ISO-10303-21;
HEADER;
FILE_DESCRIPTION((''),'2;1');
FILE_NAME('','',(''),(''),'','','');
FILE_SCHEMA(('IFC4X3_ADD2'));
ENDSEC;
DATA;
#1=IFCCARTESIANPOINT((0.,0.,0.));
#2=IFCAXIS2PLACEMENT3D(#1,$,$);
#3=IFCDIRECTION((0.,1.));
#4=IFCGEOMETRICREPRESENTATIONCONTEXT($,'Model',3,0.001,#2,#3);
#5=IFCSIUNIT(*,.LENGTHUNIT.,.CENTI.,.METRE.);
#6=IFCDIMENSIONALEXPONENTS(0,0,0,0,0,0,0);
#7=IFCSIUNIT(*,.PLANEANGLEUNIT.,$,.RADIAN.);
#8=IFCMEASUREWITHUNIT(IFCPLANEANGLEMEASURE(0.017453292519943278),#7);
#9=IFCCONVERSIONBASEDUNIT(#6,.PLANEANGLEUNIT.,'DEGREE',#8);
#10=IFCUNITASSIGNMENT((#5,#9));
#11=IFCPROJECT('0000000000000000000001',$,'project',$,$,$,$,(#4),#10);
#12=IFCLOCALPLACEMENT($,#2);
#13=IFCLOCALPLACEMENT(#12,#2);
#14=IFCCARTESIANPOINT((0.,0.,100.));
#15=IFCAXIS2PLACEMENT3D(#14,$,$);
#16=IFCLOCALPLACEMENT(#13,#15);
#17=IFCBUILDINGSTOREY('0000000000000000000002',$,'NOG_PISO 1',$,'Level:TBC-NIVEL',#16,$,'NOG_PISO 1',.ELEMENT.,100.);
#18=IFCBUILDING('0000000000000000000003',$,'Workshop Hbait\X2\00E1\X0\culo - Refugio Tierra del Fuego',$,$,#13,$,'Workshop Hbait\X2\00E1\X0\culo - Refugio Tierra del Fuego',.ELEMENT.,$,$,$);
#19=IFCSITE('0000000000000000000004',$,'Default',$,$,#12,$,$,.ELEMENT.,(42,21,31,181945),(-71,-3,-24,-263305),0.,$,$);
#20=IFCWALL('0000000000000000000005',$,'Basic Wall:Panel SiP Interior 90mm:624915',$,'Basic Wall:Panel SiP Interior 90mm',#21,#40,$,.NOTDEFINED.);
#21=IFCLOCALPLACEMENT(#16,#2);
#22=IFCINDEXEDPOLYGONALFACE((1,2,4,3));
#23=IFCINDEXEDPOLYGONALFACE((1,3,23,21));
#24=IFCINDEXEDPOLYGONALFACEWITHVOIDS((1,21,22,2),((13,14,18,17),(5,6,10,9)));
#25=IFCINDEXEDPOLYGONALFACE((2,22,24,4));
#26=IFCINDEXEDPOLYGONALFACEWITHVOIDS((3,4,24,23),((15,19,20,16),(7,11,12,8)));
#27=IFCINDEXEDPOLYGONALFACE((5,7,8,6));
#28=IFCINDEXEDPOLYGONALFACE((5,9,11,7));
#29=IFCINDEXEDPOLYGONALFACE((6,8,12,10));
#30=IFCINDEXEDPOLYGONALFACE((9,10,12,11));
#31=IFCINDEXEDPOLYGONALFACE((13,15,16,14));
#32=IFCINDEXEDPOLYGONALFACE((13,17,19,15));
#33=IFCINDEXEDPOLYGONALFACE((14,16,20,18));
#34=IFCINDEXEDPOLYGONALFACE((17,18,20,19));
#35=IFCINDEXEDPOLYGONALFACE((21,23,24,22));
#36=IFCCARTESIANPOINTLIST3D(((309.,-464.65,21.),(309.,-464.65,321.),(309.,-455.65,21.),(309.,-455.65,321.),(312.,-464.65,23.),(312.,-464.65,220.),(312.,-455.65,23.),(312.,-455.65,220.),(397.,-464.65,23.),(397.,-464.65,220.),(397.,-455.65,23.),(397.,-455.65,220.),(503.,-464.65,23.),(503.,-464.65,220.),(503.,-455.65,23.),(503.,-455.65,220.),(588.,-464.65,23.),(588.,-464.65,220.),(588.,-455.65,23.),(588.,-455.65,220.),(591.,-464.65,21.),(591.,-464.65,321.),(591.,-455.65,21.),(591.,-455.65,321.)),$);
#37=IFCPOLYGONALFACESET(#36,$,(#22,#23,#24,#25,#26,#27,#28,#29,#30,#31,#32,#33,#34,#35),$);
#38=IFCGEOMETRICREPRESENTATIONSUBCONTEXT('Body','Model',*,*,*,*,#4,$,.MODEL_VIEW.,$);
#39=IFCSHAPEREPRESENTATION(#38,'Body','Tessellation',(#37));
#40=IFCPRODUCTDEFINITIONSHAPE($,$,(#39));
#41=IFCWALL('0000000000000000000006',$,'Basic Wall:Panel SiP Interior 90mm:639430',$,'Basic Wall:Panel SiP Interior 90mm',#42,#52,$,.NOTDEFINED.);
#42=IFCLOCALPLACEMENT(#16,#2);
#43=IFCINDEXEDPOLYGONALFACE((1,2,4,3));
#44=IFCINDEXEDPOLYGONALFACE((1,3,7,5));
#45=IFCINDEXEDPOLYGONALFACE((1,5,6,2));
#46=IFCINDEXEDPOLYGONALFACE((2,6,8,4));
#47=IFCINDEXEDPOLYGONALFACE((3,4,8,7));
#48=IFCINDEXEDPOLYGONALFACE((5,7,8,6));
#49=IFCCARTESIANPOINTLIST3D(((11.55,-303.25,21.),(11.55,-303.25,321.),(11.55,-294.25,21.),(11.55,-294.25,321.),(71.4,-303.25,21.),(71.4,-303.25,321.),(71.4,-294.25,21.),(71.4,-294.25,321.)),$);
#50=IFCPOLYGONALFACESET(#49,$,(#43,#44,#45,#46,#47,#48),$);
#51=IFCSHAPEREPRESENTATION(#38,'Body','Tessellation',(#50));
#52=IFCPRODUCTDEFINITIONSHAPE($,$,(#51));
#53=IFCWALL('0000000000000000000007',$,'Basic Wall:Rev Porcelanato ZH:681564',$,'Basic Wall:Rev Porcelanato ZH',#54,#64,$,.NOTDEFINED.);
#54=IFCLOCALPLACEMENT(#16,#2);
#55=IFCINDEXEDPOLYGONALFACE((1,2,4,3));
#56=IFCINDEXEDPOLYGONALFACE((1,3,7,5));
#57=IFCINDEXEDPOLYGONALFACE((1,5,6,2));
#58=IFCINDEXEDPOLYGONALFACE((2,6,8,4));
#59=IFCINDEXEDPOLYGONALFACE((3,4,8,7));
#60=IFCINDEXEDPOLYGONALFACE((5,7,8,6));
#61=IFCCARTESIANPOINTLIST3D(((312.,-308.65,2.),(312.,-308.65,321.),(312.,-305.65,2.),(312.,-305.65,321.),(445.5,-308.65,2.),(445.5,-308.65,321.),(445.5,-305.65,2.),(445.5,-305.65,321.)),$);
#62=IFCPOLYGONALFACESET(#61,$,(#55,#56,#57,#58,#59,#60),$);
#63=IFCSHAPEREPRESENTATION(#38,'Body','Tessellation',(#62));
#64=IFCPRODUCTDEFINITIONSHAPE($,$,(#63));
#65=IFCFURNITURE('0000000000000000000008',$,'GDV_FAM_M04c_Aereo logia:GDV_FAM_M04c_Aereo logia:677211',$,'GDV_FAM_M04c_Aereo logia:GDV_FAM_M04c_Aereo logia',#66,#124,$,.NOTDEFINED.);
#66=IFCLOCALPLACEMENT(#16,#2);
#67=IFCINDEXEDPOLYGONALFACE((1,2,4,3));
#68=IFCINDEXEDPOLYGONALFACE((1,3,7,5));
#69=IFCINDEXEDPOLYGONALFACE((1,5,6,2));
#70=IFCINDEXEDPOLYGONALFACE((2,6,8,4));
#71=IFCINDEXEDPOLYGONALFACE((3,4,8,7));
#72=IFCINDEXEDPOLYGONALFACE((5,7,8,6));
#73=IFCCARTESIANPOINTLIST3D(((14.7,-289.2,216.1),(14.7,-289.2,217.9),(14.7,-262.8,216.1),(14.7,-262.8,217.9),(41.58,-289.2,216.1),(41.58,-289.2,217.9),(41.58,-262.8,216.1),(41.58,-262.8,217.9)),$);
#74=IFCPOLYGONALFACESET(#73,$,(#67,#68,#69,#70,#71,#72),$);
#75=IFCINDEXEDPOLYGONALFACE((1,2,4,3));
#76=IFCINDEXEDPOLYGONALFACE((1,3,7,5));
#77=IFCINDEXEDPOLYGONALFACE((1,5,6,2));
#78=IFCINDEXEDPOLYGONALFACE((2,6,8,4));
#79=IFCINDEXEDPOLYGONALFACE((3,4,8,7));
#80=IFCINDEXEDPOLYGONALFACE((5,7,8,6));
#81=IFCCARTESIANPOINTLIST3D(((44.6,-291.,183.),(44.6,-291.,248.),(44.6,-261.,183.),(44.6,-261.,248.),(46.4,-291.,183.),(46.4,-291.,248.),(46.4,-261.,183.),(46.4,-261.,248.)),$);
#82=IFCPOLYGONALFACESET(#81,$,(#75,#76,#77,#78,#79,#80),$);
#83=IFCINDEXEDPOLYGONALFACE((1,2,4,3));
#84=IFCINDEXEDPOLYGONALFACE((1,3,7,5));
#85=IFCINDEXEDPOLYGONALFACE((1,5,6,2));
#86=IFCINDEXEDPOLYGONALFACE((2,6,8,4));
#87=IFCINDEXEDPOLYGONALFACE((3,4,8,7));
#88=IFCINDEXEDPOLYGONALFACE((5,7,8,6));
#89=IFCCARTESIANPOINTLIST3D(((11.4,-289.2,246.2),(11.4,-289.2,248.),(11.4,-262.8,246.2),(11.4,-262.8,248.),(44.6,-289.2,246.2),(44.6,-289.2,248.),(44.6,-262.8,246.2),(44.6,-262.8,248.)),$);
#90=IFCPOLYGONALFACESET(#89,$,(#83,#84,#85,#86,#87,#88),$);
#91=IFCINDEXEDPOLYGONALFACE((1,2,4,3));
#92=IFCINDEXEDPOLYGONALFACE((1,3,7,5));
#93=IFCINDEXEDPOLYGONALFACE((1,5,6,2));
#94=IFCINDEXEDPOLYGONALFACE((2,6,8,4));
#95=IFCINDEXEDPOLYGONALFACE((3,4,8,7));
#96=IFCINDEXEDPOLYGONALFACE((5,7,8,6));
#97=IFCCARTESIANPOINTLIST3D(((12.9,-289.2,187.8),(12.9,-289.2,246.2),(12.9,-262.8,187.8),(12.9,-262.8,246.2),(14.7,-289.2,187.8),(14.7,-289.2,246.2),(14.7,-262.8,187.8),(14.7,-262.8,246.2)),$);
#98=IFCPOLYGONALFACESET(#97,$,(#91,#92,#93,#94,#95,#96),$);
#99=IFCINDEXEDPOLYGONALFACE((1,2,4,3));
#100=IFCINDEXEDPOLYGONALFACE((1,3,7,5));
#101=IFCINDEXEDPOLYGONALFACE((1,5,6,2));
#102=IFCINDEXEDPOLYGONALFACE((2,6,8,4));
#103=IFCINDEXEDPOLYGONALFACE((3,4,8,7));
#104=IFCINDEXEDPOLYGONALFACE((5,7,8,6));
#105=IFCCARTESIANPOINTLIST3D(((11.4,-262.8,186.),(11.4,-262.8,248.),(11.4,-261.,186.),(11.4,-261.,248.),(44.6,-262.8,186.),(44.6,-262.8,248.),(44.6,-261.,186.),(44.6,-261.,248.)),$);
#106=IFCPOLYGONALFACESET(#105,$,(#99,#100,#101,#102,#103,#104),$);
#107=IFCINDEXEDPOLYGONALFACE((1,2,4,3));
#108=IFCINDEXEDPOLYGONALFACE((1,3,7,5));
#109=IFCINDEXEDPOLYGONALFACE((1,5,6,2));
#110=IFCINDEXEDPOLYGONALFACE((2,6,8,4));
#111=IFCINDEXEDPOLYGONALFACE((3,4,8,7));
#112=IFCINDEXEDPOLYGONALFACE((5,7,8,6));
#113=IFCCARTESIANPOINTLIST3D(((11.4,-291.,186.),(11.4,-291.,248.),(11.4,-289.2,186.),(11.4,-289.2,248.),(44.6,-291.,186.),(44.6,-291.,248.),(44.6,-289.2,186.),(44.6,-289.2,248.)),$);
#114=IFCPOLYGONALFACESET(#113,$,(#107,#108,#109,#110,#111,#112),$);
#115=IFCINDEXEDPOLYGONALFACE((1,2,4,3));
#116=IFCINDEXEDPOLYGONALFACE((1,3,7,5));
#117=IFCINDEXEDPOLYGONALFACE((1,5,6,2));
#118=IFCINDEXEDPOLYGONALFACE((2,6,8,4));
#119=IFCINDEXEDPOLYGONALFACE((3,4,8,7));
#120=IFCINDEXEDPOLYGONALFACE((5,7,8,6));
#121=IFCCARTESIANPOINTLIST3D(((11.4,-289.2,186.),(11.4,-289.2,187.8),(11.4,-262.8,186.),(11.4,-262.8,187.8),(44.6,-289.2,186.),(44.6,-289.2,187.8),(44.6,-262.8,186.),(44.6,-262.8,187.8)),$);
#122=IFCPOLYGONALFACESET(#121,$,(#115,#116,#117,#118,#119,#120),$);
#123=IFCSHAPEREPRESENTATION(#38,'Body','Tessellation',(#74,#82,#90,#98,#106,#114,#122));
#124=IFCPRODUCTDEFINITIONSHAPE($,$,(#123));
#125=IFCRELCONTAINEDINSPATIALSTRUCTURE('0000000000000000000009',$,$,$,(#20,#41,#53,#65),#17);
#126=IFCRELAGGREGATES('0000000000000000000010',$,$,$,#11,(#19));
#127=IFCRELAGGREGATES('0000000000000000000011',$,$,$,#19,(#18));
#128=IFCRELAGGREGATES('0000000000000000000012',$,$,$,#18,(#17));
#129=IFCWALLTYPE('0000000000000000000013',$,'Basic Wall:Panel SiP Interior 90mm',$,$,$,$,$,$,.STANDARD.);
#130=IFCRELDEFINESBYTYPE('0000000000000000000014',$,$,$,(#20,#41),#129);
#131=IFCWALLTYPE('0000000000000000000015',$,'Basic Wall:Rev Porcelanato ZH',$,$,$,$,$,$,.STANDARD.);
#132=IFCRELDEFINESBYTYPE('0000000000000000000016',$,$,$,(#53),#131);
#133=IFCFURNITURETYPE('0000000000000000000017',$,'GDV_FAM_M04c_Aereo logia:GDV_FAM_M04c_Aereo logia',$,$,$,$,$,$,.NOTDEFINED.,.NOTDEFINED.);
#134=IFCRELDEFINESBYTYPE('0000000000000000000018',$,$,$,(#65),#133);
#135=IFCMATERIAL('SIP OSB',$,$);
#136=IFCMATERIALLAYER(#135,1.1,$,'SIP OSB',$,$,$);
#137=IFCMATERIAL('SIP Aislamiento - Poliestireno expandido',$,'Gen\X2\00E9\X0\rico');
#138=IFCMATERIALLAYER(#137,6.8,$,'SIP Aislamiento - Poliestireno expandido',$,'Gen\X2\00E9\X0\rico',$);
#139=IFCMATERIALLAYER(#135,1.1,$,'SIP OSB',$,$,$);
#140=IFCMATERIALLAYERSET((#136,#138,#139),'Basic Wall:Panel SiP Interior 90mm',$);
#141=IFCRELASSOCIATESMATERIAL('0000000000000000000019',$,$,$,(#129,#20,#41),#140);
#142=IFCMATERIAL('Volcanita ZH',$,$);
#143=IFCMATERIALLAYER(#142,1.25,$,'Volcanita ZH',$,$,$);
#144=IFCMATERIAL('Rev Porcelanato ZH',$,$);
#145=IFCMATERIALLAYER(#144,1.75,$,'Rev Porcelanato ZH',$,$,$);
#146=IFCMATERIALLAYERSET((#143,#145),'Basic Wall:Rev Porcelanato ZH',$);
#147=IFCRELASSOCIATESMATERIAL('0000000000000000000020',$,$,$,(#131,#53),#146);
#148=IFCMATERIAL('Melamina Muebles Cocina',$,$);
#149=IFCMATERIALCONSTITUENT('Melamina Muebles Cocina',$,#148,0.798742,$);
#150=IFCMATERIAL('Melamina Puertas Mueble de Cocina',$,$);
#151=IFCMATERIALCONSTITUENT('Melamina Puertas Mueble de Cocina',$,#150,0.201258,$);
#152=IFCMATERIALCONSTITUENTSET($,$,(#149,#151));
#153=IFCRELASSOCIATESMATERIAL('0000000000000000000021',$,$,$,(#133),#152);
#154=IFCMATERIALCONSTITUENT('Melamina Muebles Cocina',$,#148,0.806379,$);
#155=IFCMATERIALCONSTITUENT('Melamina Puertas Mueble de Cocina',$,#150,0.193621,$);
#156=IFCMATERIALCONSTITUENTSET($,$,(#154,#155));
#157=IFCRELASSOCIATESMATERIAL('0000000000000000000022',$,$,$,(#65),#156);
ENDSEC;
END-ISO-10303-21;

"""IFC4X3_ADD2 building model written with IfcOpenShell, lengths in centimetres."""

from ifc_helpers import new_model, entity, si_unit, converted_unit, direction, frame, frame_2d, origin, origin_2d_with_axis, place, context, subcontext, project, spatial, rectangle, extrude, source, transform, mapped, material, layer, layer_set, constituent, constituent_set, type_object, type_shapes, element, save


model = new_model("IFC4X3_ADD2")

# Units and contexts
model_context = context("Model", 3, precision=0.001, world=origin(), true_north=direction((0.0, 1.0)))
body_context = subcontext(model_context, "Body", "Model", "MODEL_VIEW")
ifc_project = project(units=[si_unit("LENGTHUNIT", "METRE", prefix="CENTI"), converted_unit("PLANEANGLEUNIT", "DEGREE", entity("IfcPlaneAngleMeasure", 0.017453292519943278), si_unit("PLANEANGLEUNIT", "RADIAN"), dimensions=[0, 0, 0, 0, 0, 0, 0])], contexts=[model_context])

# Site, building, storey
site_placement = place(None, origin())
site = spatial("IfcSite", under=ifc_project, at=site_placement, Name="Default", CompositionType="ELEMENT", RefLatitude=(42, 21, 31, 181945), RefLongitude=(-71, -3, -24, -263305), RefElevation=0.0)
building_placement = place(site_placement, origin())
building = spatial("IfcBuilding", under=site, at=building_placement, Name="Workshop Hbaitáculo - Refugio Tierra del Fuego", LongName="Workshop Hbaitáculo - Refugio Tierra del Fuego", CompositionType="ELEMENT")
storey_placement = place(building_placement, frame((0.0, 0.0, 100.0)))
storey = spatial("IfcBuildingStorey", under=building, at=storey_placement, Name="NOG_PISO 1", ObjectType="Level:TBC-NIVEL", LongName="NOG_PISO 1", CompositionType="ELEMENT", Elevation=100.0)

# Shared definitions
ifc_material_1 = material(Name="SIP OSB")
ifc_material_2 = material(Name="SIP Aislamiento - Poliestireno expandido", Category="Genérico")

# Shared definitions
ifc_layer_1 = layer(ifc_material_1, 1.1, Name="SIP OSB")
ifc_layer_2 = layer(ifc_material_2, 6.8, Name="SIP Aislamiento - Poliestireno expandido", Category="Genérico")
ifc_layer_3 = layer(ifc_material_1, 1.1, Name="SIP OSB")
ifc_layer_set_1 = layer_set([ifc_layer_1, ifc_layer_2, ifc_layer_3], Name="Basic Wall:Panel SiP Interior 90mm")
wall_type_1 = type_object("IfcWallType", Name="Basic Wall:Panel SiP Interior 90mm", PredefinedType="STANDARD", material=ifc_layer_set_1)

# Wall, openings
wall_1_placement = place(storey_placement, frame((309.0, -460.15, 21.0)))
wall_1 = element("IfcWall", 1, at=wall_1_placement, inside=storey, type_object=wall_type_1, material=ifc_layer_set_1, Name="Basic Wall:Panel SiP Interior 90mm:624915", ObjectType="Basic Wall:Panel SiP Interior 90mm", PredefinedType="NOTDEFINED", context=body_context, shape_type="SweptSolid", body=[
    extrude(rectangle(XDim=282.0, YDim=9.0, at=frame_2d((141.0, 0.0), x_axis=(-1.0, 0.0))), origin(), (0.0, 0.0, 1.0), 300.0),
])
opening_1_placement = place(wall_1_placement, frame((3.0, -4.5, 2.0)))
element("IfcOpeningElement", 2, at=opening_1_placement, cuts=wall_1, PredefinedType="OPENING", context=body_context, shape_type="SweptSolid", body=[
    extrude(rectangle(XDim=197.0, YDim=85.0, at=frame_2d((98.5, 42.5), x_axis=(1.0, 0.0))), frame((0.0, 0.0, 0.0), z_axis=(0.0, 1.0, 0.0), x_axis=(0.0, 0.0, 1.0)), (0.0, 0.0, 1.0), 9.0),
])
opening_2_placement = place(wall_1_placement, frame((194.0, -4.5, 2.0)))
element("IfcOpeningElement", 3, at=opening_2_placement, cuts=wall_1, PredefinedType="OPENING", context=body_context, shape_type="SweptSolid", body=[
    extrude(rectangle(XDim=197.0, YDim=85.0, at=frame_2d((98.5, 42.5), x_axis=(1.0, 0.0))), frame((0.0, 0.0, 0.0), z_axis=(0.0, 1.0, 0.0), x_axis=(0.0, 0.0, 1.0)), (0.0, 0.0, 1.0), 9.0),
])

# Walls
wall_2_placement = place(storey_placement, frame((71.4, -298.75, 21.0), z_axis=(0.0, 0.0, 1.0), x_axis=(-1.0, 0.0, 0.0)))
element("IfcWall", 4, at=wall_2_placement, inside=storey, type_object=wall_type_1, material=ifc_layer_set_1, Name="Basic Wall:Panel SiP Interior 90mm:639430", ObjectType="Basic Wall:Panel SiP Interior 90mm", PredefinedType="NOTDEFINED", context=body_context, shape_type="SweptSolid", body=[
    extrude(rectangle(XDim=59.85, YDim=9.0, at=frame_2d((29.93, 0.0), x_axis=(-1.0, 0.0))), origin(), (0.0, 0.0, 1.0), 300.0),
])
ifc_material_3 = material(Name="Volcanita ZH")
ifc_layer_4 = layer(ifc_material_3, 1.25, Name="Volcanita ZH")
ifc_material_4 = material(Name="Rev Porcelanato ZH")
ifc_layer_5 = layer(ifc_material_4, 1.75, Name="Rev Porcelanato ZH")
ifc_layer_set_2 = layer_set([ifc_layer_4, ifc_layer_5], Name="Basic Wall:Rev Porcelanato ZH")
wall_type_2 = type_object("IfcWallType", Name="Basic Wall:Rev Porcelanato ZH", PredefinedType="STANDARD", material=ifc_layer_set_2)
wall_3_placement = place(storey_placement, frame((312.0, -307.15, 2.0)))
element("IfcWall", 5, at=wall_3_placement, inside=storey, type_object=wall_type_2, material=ifc_layer_set_2, Name="Basic Wall:Rev Porcelanato ZH:681564", ObjectType="Basic Wall:Rev Porcelanato ZH", PredefinedType="NOTDEFINED", context=body_context, shape_type="SweptSolid", body=[
    extrude(rectangle(XDim=133.5, YDim=3.0, at=frame_2d((66.75, 0.0), x_axis=(-1.0, 0.0))), origin(), (0.0, 0.0, 1.0), 319.0),
])

# Furniture
ifc_material_5 = material(Name="Melamina Muebles Cocina")
ifc_constituent_1 = constituent(ifc_material_5, Name="Melamina Muebles Cocina", fraction=0.806379)
ifc_material_6 = material(Name="Melamina Puertas Mueble de Cocina")
ifc_constituent_2 = constituent(ifc_material_6, Name="Melamina Puertas Mueble de Cocina", fraction=0.193621)
ifc_constituent_set_1 = constituent_set(constituents=[ifc_constituent_1, ifc_constituent_2])
ifc_constituent_3 = constituent(ifc_material_5, Name="Melamina Muebles Cocina", fraction=0.798742)
ifc_constituent_4 = constituent(ifc_material_6, Name="Melamina Puertas Mueble de Cocina", fraction=0.201258)
ifc_constituent_set_2 = constituent_set(constituents=[ifc_constituent_3, ifc_constituent_4])
furniture_type = type_object("IfcFurnitureType", Name="GDV_FAM_M04c_Aereo logia:GDV_FAM_M04c_Aereo logia", AssemblyPlace="NOTDEFINED", PredefinedType="NOTDEFINED", material=ifc_constituent_set_2)
shared_shape_1 = source(origin(), body_context, "Body", "SweptSolid", [
    extrude(rectangle(XDim=26.4, YDim=26.88, at=frame_2d((0.0, 0.0), x_axis=(1.0, 0.0))), frame((15.0, -16.74, 33.1), z_axis=(0.0, 0.0, 1.0), x_axis=(-1.0, 0.0, 0.0)), (0.0, 0.0, 1.0), 1.8),
    extrude(rectangle(XDim=30.0, YDim=1.8, at=frame_2d((0.0, 0.0), x_axis=(1.0, 0.0))), frame((15.0, -34.1, 0.0), z_axis=(0.0, 0.0, 1.0), x_axis=(-1.0, 0.0, 0.0)), (0.0, 0.0, 1.0), 65.0),
    extrude(rectangle(XDim=26.4, YDim=33.2, at=origin_2d_with_axis()), frame((15.0, -16.6, 63.2), z_axis=(0.0, 0.0, 1.0), x_axis=(-1.0, 0.0, 0.0)), (0.0, 0.0, 1.0), 1.8),
    extrude(rectangle(XDim=26.4, YDim=1.8, at=origin_2d_with_axis()), frame((15.0, -2.4, 4.8), z_axis=(0.0, 0.0, 1.0), x_axis=(-1.0, 0.0, 0.0)), (0.0, 0.0, 1.0), 58.4),
    extrude(rectangle(XDim=33.2, YDim=1.8, at=origin_2d_with_axis()), frame((29.1, -16.6, 3.0), z_axis=(0.0, 0.0, 1.0), x_axis=(0.0, 1.0, 0.0)), (0.0, 0.0, 1.0), 62.0),
    extrude(rectangle(XDim=33.2, YDim=1.8, at=origin_2d_with_axis()), frame((0.9, -16.6, 3.0), z_axis=(0.0, 0.0, 1.0), x_axis=(0.0, 1.0, 0.0)), (0.0, 0.0, 1.0), 62.0),
    extrude(rectangle(XDim=26.4, YDim=33.2, at=origin_2d_with_axis()), frame((15.0, -16.6, 3.0), z_axis=(0.0, 0.0, 1.0), x_axis=(-1.0, 0.0, 0.0)), (0.0, 0.0, 1.0), 1.8),
])
type_shapes(furniture_type, [shared_shape_1])
furniture_placement = place(storey_placement, frame((11.4, -291.0, 183.0), z_axis=(0.0, 0.0, 1.0), x_axis=(0.0, 1.0, 0.0)))
element("IfcFurniture", 6, at=furniture_placement, inside=storey, type_object=furniture_type, material=ifc_constituent_set_1, Name="GDV_FAM_M04c_Aereo logia:GDV_FAM_M04c_Aereo logia:677211", ObjectType="GDV_FAM_M04c_Aereo logia:GDV_FAM_M04c_Aereo logia", PredefinedType="NOTDEFINED", context=body_context, shape_type="MappedRepresentation", body=[
    mapped(shared_shape_1, transform((0.0, 0.0, 0.0), scale=1.0)),
])

save(model, "model.ifc")
